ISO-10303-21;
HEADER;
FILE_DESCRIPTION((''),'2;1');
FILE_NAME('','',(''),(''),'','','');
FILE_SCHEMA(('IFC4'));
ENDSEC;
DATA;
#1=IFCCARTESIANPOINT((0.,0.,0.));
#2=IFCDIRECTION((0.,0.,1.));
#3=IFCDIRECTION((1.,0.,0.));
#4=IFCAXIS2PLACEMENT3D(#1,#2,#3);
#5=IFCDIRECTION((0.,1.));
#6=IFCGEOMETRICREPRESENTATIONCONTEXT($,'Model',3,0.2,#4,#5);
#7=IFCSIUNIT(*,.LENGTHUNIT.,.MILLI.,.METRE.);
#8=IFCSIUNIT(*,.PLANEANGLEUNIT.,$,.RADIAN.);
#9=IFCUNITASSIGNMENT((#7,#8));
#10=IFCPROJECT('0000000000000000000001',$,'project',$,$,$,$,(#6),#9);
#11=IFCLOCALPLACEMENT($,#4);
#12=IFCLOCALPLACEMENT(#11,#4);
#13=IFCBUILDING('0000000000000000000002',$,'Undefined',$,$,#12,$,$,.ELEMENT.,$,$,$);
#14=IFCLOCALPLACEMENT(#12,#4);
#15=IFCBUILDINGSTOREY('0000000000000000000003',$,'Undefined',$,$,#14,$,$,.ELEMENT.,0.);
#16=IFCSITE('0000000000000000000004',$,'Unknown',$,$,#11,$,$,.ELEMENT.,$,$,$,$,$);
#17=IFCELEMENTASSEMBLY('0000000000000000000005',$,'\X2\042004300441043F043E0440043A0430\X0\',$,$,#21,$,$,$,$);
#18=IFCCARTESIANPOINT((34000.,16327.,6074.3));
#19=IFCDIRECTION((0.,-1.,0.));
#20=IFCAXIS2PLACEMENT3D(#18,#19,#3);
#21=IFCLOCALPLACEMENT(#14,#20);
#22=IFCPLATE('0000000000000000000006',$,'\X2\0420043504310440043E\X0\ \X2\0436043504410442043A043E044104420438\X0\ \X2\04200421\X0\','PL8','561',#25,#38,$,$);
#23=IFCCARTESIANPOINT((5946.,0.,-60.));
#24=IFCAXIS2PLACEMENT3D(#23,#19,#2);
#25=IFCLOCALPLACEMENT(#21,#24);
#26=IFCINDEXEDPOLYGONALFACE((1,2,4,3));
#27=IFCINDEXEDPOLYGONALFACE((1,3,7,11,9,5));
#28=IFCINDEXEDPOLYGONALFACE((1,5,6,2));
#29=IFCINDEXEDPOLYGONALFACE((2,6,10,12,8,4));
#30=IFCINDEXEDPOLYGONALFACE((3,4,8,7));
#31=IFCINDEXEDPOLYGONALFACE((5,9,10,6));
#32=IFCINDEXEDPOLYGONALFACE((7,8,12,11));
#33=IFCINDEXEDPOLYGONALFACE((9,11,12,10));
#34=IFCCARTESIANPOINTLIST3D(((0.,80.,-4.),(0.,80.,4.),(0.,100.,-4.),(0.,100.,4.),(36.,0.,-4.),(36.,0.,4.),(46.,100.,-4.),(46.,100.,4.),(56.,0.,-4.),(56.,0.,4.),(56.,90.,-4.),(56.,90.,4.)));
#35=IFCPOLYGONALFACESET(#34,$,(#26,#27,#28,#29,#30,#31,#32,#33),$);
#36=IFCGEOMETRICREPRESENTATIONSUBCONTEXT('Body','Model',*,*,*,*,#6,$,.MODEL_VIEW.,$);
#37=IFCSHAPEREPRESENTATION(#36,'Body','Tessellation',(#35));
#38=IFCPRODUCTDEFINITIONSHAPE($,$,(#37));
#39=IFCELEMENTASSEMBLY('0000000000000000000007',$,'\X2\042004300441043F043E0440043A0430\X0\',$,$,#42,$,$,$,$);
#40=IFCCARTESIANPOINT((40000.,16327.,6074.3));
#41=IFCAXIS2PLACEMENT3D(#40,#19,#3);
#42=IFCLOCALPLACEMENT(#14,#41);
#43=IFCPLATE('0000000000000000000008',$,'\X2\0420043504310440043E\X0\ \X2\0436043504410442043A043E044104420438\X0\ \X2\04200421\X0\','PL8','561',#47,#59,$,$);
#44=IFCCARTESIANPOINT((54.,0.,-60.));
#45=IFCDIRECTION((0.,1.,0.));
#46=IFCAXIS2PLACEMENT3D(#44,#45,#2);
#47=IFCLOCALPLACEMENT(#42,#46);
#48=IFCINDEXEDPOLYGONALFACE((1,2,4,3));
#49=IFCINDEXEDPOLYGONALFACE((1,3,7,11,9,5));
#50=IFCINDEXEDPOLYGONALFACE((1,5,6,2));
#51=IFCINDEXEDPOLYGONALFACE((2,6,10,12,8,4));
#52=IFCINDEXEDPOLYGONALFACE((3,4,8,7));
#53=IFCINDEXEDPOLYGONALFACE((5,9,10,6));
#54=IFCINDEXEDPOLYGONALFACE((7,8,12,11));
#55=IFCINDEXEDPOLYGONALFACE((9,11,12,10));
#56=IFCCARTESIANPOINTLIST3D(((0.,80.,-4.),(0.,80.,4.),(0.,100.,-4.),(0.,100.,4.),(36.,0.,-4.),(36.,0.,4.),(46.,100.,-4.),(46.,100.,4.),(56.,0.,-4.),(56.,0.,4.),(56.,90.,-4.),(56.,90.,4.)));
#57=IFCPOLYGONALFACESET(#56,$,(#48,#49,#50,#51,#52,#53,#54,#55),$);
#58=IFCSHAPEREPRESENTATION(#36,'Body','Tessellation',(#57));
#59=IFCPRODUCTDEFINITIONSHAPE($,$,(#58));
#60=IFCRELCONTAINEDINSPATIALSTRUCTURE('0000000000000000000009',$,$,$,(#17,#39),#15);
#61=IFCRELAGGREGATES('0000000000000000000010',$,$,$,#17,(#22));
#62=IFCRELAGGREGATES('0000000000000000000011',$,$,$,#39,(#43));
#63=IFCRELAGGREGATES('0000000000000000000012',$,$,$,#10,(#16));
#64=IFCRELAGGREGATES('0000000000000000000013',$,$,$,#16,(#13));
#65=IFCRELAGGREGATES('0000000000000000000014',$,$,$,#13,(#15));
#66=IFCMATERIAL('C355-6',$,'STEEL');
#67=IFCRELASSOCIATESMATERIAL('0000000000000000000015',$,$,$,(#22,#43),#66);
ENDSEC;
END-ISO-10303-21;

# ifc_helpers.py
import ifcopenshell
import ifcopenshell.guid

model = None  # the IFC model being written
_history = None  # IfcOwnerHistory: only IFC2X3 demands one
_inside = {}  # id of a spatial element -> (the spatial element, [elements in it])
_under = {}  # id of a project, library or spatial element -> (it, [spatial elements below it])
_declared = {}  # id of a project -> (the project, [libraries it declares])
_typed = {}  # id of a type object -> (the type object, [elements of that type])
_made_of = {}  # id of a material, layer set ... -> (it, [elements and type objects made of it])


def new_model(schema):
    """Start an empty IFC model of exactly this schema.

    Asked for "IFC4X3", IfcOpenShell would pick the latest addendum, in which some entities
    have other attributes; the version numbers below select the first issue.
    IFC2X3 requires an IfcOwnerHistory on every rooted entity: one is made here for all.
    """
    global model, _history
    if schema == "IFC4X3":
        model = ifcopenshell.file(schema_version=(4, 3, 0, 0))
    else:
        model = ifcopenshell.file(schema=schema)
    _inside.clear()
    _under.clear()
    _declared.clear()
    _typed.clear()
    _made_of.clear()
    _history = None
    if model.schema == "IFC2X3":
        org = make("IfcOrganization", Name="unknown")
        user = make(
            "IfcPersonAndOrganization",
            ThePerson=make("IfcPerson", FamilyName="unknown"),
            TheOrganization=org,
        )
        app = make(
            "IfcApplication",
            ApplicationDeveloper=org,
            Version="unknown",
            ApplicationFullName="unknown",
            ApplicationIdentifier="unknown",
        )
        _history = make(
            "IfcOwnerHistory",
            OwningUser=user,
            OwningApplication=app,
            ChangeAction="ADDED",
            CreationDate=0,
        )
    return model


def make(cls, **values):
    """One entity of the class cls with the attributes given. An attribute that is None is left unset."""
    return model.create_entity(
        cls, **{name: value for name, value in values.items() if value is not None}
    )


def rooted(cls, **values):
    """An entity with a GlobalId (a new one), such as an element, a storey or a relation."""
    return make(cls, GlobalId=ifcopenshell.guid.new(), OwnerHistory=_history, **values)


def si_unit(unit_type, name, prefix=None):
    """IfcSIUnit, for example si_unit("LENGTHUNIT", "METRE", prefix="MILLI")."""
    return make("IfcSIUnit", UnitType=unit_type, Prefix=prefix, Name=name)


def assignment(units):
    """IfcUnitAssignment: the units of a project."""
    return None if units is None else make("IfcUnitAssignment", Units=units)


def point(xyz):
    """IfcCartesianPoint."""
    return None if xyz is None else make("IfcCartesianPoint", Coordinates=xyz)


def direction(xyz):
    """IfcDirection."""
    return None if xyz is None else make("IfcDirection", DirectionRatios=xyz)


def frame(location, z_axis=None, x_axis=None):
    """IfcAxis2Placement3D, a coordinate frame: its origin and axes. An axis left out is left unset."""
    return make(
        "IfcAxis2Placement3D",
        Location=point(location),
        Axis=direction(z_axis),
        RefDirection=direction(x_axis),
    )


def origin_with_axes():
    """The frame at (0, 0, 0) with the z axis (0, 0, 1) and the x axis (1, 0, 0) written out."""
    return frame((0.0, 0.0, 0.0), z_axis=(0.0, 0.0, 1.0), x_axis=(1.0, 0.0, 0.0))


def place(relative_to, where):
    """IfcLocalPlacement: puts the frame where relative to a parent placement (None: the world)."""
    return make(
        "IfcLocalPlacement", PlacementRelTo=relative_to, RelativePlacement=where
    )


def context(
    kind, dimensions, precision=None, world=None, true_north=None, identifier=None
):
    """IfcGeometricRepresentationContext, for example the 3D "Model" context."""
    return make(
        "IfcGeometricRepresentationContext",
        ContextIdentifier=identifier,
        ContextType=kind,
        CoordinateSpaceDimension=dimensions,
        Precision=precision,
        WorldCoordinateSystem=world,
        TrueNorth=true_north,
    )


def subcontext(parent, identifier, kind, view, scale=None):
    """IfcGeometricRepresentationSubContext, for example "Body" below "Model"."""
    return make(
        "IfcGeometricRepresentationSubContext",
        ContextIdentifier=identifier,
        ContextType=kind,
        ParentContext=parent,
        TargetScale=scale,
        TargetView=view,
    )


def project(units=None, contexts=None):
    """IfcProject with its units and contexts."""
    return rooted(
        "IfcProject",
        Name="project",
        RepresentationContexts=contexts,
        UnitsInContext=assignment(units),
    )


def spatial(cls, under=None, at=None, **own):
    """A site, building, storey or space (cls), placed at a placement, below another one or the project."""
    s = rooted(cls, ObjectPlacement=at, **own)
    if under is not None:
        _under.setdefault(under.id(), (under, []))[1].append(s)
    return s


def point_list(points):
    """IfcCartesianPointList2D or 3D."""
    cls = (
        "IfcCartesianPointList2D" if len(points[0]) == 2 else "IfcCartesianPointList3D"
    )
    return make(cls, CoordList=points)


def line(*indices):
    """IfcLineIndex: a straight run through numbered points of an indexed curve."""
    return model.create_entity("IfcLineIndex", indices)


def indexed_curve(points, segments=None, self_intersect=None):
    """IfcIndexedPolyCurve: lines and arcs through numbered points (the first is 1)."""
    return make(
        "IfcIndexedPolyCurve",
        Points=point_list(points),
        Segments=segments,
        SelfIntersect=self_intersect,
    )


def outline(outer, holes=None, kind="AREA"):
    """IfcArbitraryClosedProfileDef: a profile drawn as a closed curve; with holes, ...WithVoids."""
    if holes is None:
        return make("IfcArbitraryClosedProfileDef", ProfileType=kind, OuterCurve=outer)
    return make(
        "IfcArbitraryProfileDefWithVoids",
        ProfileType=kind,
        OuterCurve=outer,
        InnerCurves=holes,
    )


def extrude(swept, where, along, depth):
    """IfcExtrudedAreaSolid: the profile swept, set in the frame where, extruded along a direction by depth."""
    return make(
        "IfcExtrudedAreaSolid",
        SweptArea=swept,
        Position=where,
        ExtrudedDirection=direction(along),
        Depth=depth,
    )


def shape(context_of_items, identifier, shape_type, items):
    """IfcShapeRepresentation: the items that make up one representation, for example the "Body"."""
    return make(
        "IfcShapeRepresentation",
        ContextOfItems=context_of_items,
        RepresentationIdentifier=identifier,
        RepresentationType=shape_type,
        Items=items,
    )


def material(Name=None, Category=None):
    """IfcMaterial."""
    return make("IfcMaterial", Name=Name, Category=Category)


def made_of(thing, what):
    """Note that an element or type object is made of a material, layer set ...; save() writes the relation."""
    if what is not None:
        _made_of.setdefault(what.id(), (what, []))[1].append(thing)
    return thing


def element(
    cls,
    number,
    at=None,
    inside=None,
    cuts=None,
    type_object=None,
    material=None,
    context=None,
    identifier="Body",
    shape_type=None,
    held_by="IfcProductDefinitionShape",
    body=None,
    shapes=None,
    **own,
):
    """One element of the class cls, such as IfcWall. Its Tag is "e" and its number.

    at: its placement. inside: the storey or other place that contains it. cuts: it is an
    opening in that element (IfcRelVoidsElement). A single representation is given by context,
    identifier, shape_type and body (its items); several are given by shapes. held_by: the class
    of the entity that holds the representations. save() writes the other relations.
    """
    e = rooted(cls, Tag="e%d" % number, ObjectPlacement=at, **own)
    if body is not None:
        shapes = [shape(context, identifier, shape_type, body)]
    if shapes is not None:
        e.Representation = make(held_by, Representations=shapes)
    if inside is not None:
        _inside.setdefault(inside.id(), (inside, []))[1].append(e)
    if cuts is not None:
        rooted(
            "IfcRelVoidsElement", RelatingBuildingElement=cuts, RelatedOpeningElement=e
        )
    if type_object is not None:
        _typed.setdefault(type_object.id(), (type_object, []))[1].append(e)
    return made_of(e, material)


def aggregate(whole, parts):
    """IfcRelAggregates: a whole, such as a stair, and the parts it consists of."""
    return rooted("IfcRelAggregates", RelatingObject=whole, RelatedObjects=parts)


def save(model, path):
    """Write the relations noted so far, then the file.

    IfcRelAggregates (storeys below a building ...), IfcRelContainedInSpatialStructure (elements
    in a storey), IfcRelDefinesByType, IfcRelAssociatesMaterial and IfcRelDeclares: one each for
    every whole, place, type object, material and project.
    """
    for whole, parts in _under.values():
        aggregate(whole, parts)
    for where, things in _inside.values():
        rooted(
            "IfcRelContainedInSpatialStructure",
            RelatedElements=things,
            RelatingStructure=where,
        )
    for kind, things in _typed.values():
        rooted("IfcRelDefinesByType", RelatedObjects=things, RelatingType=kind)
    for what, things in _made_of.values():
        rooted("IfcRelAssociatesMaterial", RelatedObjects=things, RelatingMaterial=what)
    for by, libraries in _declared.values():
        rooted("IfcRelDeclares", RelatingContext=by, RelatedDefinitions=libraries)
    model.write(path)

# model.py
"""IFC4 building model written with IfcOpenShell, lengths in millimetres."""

from ifc_helpers import new_model, si_unit, direction, frame, origin_with_axes, place, context, subcontext, project, spatial, line, indexed_curve, outline, extrude, material, element, aggregate, save


model = new_model("IFC4")

# Units and contexts
model_context = context("Model", 3, precision=0.2, world=origin_with_axes(), true_north=direction((0.0, 1.0)))
body_context = subcontext(model_context, "Body", "Model", "MODEL_VIEW")
ifc_project = project(units=[si_unit("LENGTHUNIT", "METRE", prefix="MILLI"), si_unit("PLANEANGLEUNIT", "RADIAN")], contexts=[model_context])

# Site, building, storey
site_placement = place(None, origin_with_axes())
site = spatial("IfcSite", under=ifc_project, at=site_placement, Name="Unknown", CompositionType="ELEMENT")
building_placement = place(site_placement, origin_with_axes())
building = spatial("IfcBuilding", under=site, at=building_placement, Name="Undefined", CompositionType="ELEMENT")
storey_placement = place(building_placement, origin_with_axes())
storey = spatial("IfcBuildingStorey", under=building, at=storey_placement, Name="Undefined", CompositionType="ELEMENT", Elevation=0.0)

# Element assemblies, plates
ifc_material_1 = material(Name="C355-6", Category="STEEL")
assembly_1_placement = place(storey_placement, frame((34000.0, 16327.0, 6074.3), z_axis=(0.0, -1.0, 0.0), x_axis=(1.0, 0.0, 0.0)))
assembly_1 = element("IfcElementAssembly", 1, at=assembly_1_placement, inside=storey, Name="Распорка")
plate_1_placement = place(assembly_1_placement, frame((5946.0, 0.0, -60.0), z_axis=(0.0, -1.0, 0.0), x_axis=(0.0, 0.0, 1.0)))
plate_1 = element("IfcPlate", 2, at=plate_1_placement, material=ifc_material_1, Name="Ребро жесткости РС", Description="PL8", ObjectType="561", context=body_context, shape_type="SolidModel", body=[
    extrude(outline(indexed_curve([(0.0, 80.0), (36.0, 0.0), (56.0, 0.0), (56.0, 90.0), (46.0, 100.0), (0.0, 100.0)], segments=[line(1, 2, 3, 4, 5, 6, 1)])), frame((0.0, 0.0, 4.0), z_axis=(0.0, 0.0, 1.0), x_axis=(1.0, 0.0, 0.0)), (0.0, 0.0, -1.0), 8.0),
])
aggregate(assembly_1, [plate_1])
assembly_2_placement = place(storey_placement, frame((40000.0, 16327.0, 6074.3), z_axis=(0.0, -1.0, 0.0), x_axis=(1.0, 0.0, 0.0)))
assembly_2 = element("IfcElementAssembly", 3, at=assembly_2_placement, inside=storey, Name="Распорка")
plate_2_placement = place(assembly_2_placement, frame((54.0, 0.0, -60.0), z_axis=(0.0, 1.0, 0.0), x_axis=(0.0, 0.0, 1.0)))
plate_2 = element("IfcPlate", 4, at=plate_2_placement, material=ifc_material_1, Name="Ребро жесткости РС", Description="PL8", ObjectType="561", context=body_context, shape_type="SolidModel", body=[
    extrude(outline(indexed_curve([(0.0, 80.0), (36.0, 0.0), (56.0, 0.0), (56.0, 90.0), (46.0, 100.0), (0.0, 100.0)], segments=[line(1, 2, 3, 4, 5, 6, 1)])), frame((0.0, 0.0, 4.0), z_axis=(0.0, 0.0, 1.0), x_axis=(1.0, 0.0, 0.0)), (0.0, 0.0, -1.0), 8.0),
])
aggregate(assembly_2, [plate_2])

save(model, "model.ifc")
